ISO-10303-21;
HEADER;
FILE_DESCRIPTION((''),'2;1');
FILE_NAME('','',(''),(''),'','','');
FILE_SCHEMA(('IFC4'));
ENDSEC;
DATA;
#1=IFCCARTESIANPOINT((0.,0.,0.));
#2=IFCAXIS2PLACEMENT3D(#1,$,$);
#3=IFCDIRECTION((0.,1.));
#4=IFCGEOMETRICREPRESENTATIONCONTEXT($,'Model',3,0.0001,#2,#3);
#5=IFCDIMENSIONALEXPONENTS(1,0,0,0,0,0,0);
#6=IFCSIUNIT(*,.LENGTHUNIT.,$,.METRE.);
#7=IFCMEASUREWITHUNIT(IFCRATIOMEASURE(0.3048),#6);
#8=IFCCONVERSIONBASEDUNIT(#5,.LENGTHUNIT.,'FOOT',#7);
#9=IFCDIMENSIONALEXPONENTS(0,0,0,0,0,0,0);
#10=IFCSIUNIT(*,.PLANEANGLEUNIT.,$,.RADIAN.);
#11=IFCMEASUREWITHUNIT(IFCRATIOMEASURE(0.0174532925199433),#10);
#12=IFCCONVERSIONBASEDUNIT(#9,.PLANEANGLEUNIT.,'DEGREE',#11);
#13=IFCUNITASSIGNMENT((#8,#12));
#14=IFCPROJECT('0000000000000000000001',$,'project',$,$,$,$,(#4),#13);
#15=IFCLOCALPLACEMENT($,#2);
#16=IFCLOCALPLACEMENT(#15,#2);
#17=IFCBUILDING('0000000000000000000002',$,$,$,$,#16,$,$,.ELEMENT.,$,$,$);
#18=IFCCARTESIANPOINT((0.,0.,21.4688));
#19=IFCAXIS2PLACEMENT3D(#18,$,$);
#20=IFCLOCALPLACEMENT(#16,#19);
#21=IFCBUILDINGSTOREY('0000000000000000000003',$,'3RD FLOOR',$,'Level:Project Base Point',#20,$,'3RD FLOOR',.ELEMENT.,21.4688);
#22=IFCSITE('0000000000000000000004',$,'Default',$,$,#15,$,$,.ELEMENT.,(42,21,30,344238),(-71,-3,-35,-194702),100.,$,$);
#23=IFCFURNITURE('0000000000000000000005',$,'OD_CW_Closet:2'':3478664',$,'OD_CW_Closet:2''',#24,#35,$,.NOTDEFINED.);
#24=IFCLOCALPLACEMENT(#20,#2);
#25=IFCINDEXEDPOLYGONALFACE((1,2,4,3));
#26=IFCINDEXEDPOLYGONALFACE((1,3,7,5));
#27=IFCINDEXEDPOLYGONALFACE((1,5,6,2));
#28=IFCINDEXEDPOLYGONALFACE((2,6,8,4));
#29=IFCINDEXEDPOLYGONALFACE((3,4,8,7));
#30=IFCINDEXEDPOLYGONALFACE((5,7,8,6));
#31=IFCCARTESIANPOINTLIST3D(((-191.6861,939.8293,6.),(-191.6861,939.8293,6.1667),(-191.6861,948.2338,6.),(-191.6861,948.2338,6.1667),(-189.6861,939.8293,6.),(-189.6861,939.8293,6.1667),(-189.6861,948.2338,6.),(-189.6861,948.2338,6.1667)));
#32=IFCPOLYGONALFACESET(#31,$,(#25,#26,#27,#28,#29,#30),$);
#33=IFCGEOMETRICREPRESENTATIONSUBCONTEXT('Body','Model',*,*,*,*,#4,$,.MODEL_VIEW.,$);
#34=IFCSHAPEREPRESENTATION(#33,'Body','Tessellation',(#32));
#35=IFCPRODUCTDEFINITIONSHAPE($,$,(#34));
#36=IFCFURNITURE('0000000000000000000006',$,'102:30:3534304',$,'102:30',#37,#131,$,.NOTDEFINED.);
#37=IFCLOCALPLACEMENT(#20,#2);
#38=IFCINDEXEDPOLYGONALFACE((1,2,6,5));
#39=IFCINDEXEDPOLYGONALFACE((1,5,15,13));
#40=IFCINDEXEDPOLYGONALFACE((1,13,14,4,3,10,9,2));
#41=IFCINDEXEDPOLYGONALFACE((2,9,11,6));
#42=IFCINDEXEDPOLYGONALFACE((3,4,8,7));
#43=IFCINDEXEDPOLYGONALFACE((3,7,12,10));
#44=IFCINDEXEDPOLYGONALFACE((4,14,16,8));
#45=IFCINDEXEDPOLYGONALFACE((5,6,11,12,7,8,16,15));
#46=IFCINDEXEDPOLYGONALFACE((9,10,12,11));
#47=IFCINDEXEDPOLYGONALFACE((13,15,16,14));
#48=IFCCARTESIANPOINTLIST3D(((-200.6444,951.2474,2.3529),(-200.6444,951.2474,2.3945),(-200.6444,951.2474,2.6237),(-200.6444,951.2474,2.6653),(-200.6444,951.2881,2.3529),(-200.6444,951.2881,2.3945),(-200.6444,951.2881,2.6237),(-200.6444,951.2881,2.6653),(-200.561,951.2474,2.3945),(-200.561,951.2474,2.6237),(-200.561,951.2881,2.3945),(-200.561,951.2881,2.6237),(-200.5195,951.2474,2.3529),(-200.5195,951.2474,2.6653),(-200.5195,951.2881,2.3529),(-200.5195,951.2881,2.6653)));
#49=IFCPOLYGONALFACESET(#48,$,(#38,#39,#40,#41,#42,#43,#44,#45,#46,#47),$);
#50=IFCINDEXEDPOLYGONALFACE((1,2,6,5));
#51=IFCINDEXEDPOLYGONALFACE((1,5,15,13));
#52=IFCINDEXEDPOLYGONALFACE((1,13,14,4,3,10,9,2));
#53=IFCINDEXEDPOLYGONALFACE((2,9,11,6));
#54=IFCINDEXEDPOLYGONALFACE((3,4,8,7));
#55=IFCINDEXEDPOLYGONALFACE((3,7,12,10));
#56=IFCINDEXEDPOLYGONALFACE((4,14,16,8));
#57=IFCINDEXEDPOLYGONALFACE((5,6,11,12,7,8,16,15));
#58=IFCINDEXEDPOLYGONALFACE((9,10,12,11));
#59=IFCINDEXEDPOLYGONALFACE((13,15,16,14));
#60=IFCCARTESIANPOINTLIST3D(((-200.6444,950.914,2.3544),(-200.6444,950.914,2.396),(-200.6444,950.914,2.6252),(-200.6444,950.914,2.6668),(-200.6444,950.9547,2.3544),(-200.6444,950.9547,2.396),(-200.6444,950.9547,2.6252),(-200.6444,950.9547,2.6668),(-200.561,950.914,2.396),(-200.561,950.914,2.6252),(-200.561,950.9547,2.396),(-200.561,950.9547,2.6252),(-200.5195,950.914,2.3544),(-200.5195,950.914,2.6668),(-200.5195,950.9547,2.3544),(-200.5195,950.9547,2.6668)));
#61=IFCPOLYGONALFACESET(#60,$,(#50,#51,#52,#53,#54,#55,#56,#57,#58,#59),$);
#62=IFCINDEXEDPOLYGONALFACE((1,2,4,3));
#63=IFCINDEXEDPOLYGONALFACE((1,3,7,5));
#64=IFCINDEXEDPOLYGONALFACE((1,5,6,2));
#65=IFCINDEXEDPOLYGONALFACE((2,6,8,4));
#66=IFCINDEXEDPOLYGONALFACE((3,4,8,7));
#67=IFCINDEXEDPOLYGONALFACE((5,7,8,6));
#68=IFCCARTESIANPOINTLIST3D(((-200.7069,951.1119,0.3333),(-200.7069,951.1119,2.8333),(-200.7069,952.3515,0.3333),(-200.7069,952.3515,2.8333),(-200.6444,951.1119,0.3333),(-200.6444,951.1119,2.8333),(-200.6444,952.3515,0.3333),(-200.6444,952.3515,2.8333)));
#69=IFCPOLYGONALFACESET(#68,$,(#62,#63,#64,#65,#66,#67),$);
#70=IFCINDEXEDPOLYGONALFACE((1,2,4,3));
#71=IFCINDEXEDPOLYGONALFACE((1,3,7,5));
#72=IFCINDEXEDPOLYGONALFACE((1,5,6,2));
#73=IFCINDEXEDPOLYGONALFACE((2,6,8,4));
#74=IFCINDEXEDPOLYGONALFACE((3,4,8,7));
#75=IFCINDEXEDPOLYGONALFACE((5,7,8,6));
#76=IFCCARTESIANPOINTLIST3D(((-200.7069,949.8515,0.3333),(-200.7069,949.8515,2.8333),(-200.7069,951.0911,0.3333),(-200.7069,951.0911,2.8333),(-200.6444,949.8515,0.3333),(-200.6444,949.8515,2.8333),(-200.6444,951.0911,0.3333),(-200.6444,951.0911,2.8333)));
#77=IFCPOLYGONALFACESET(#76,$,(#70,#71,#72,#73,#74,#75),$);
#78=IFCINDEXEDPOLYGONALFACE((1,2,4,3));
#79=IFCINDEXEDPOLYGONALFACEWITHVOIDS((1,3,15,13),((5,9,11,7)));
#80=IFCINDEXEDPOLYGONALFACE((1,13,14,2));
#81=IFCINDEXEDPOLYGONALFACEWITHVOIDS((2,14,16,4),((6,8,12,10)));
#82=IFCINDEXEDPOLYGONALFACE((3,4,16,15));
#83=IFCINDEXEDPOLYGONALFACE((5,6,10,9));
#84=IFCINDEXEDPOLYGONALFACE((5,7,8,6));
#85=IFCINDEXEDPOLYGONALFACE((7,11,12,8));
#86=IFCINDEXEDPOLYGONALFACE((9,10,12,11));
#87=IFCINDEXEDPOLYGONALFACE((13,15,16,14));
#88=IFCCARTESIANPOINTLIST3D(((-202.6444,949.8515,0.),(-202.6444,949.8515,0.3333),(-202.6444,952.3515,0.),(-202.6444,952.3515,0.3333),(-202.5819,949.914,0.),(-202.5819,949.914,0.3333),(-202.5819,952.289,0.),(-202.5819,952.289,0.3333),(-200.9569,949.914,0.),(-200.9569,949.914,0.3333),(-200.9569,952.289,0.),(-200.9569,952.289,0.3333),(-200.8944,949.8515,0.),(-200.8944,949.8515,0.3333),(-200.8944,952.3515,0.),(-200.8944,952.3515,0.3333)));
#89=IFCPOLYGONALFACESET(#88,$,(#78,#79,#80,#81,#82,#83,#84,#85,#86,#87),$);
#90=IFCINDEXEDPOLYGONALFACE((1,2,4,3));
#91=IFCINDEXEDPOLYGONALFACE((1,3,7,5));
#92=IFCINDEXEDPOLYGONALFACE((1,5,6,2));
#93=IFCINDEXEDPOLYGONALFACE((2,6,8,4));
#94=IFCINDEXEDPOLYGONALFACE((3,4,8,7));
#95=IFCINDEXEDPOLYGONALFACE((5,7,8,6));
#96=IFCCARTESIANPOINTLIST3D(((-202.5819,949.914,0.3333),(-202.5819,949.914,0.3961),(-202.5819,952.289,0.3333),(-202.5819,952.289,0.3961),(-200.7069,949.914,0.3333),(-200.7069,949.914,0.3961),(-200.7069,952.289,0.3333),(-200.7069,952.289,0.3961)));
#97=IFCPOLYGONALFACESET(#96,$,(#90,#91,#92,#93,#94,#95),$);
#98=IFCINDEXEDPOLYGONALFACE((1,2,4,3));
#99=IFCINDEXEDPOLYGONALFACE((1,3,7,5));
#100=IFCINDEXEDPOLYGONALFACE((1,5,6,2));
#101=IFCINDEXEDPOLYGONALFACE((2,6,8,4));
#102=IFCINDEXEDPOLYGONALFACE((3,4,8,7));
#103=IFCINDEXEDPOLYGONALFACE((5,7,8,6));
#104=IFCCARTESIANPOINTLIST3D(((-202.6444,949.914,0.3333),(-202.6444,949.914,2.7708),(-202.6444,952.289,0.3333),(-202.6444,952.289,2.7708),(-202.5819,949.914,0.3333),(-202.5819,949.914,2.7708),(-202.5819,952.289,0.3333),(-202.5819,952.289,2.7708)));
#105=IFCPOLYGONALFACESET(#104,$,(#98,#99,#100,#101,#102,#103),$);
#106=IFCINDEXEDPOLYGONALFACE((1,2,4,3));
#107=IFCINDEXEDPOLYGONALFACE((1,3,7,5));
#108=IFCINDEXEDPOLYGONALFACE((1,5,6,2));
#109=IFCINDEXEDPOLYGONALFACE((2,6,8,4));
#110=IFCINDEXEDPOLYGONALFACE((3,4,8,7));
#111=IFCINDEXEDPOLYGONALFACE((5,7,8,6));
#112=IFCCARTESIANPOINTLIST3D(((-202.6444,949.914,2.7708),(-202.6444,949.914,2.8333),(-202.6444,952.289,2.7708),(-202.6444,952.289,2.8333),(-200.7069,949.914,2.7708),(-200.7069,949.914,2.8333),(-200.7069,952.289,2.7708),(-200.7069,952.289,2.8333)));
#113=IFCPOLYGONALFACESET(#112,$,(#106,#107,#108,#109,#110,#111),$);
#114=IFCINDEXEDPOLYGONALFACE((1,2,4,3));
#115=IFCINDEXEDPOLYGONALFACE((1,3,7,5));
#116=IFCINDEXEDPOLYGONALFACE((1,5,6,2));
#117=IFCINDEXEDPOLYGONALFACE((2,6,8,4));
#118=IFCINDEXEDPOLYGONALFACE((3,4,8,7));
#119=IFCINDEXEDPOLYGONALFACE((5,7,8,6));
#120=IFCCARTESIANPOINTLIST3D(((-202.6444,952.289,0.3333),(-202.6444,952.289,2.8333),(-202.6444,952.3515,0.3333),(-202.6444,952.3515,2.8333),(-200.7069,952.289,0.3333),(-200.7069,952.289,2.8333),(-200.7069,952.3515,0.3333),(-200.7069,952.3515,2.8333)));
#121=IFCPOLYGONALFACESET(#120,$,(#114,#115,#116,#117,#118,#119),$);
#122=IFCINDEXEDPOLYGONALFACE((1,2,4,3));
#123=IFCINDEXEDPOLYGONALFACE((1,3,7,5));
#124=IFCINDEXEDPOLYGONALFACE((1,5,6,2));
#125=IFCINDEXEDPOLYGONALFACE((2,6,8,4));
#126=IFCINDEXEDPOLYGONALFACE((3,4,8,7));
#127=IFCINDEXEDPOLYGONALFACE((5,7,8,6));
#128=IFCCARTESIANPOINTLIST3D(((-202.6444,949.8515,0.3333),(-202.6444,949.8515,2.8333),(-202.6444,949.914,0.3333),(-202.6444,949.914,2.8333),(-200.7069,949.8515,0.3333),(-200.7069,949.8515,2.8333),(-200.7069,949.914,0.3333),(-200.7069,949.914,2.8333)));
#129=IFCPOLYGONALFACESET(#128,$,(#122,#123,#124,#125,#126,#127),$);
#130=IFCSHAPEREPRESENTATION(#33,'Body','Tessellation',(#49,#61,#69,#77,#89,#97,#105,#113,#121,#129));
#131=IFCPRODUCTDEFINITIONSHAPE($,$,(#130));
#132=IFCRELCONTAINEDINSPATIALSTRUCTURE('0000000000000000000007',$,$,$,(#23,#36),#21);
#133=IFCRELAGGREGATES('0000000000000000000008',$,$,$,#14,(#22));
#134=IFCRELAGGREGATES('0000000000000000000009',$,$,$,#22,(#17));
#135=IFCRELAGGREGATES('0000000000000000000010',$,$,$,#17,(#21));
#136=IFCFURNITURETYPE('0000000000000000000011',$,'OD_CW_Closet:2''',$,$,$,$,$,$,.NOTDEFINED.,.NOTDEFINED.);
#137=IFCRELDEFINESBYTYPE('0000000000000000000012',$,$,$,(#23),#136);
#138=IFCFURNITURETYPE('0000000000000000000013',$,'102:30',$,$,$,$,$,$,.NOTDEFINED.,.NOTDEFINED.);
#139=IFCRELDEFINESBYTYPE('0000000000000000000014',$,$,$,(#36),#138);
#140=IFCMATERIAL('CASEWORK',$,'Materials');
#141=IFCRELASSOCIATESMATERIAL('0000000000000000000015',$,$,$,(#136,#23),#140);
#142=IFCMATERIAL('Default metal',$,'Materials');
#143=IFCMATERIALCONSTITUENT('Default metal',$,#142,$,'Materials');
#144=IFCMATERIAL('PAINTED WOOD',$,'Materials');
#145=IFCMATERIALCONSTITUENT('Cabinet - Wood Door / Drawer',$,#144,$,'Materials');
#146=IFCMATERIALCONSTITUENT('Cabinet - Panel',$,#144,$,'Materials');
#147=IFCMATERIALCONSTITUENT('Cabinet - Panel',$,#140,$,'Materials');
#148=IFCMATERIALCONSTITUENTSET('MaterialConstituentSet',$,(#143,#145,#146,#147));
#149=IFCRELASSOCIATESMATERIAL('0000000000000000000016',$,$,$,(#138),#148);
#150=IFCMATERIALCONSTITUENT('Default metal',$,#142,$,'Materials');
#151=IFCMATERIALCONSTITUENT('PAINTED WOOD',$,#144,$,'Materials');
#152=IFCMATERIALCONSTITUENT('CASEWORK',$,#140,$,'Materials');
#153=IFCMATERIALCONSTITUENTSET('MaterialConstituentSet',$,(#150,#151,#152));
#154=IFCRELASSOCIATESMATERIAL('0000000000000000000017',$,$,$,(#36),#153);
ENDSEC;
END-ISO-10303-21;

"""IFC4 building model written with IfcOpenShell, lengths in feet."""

from ifc_helpers import new_model, entity, si_unit, converted_unit, direction, frame, frame_2d, origin, origin_2d_with_axis, place, context, subcontext, project, spatial, polyline, rectangle, outline, extrude, source, transform, mapped, material, constituent, constituent_set, type_object, type_shapes, element, save


model = new_model("IFC4")

# Units and contexts
model_context = context("Model", 3, precision=0.0001, world=origin(), true_north=direction((0.0, 1.0)))
body_context = subcontext(model_context, "Body", "Model", "MODEL_VIEW")
ifc_project = project(units=[converted_unit("LENGTHUNIT", "FOOT", entity("IfcRatioMeasure", 0.3048), si_unit("LENGTHUNIT", "METRE"), dimensions=[1, 0, 0, 0, 0, 0, 0]), converted_unit("PLANEANGLEUNIT", "DEGREE", entity("IfcRatioMeasure", 0.0174532925199433), si_unit("PLANEANGLEUNIT", "RADIAN"), dimensions=[0, 0, 0, 0, 0, 0, 0])], contexts=[model_context])

# Site, building, storey
site_placement = place(None, origin())
site = spatial("IfcSite", under=ifc_project, at=site_placement, Name="Default", CompositionType="ELEMENT", RefLatitude=(42, 21, 30, 344238), RefLongitude=(-71, -3, -35, -194702), RefElevation=100.0)
building_placement = place(site_placement, origin())
building = spatial("IfcBuilding", under=site, at=building_placement, CompositionType="ELEMENT")
storey_placement = place(building_placement, frame((0.0, 0.0, 21.4688)))
storey = spatial("IfcBuildingStorey", under=building, at=storey_placement, Name="3RD FLOOR", ObjectType="Level:Project Base Point", LongName="3RD FLOOR", CompositionType="ELEMENT", Elevation=21.4688)

# Furniture
ifc_material_1 = material(Name="Default metal", Category="Materials")
ifc_material_2 = material(Name="PAINTED WOOD", Category="Materials")
ifc_material_3 = material(Name="CASEWORK", Category="Materials")
furniture_type_1 = type_object("IfcFurnitureType", Name="OD_CW_Closet:2'", AssemblyPlace="NOTDEFINED", PredefinedType="NOTDEFINED", material=ifc_material_3)
shared_shape_1 = source(origin(), body_context, "Body", "SweptSolid", [
    extrude(rectangle(XDim=8.4045, YDim=2.0, at=frame_2d((0.0, 0.0), x_axis=(1.0, 0.0))), frame((4.2022, 1.0, 0.0)), (0.0, 0.0, 1.0), 0.1667),
])
type_shapes(furniture_type_1, [shared_shape_1])
furniture_1_placement = place(storey_placement, frame((-191.6861, 948.2338, 6.0), z_axis=(0.0, 0.0, 1.0), x_axis=(0.0, -1.0, 0.0)))
element("IfcFurniture", 1, at=furniture_1_placement, inside=storey, type_object=furniture_type_1, material=ifc_material_3, Name="OD_CW_Closet:2':3478664", ObjectType="OD_CW_Closet:2'", PredefinedType="NOTDEFINED", context=body_context, shape_type="MappedRepresentation", body=[
    mapped(shared_shape_1, transform((0.0, 0.0, 0.0), scale=1.0)),
])
ifc_constituent_1 = constituent(ifc_material_1, Name="Default metal", Category="Materials")
ifc_constituent_2 = constituent(ifc_material_2, Name="PAINTED WOOD", Category="Materials")
ifc_constituent_3 = constituent(ifc_material_3, Name="CASEWORK", Category="Materials")
ifc_constituent_set_1 = constituent_set(constituents=[ifc_constituent_1, ifc_constituent_2, ifc_constituent_3], Name="MaterialConstituentSet")
ifc_constituent_4 = constituent(ifc_material_1, Name="Default metal", Category="Materials")
ifc_constituent_5 = constituent(ifc_material_2, Name="Cabinet - Wood Door / Drawer", Category="Materials")
ifc_constituent_6 = constituent(ifc_material_2, Name="Cabinet - Panel", Category="Materials")
ifc_constituent_7 = constituent(ifc_material_3, Name="Cabinet - Panel", Category="Materials")
ifc_constituent_set_2 = constituent_set(constituents=[ifc_constituent_4, ifc_constituent_5, ifc_constituent_6, ifc_constituent_7], Name="MaterialConstituentSet")
furniture_type_2 = type_object("IfcFurnitureType", Name="102:30", AssemblyPlace="NOTDEFINED", PredefinedType="NOTDEFINED", material=ifc_constituent_set_2)
shared_shape_2 = source(origin(), body_context, "Body", "SweptSolid", [
    extrude(outline(polyline([(0.1146, -0.0521), (0.1562, -0.0521), (0.1562, 0.0729), (-0.1562, 0.0729), (-0.1562, -0.0521), (-0.1146, -0.0521), (-0.1146, 0.0313), (0.1146, 0.0313), (0.1146, -0.0521)])), frame((0.2073, -2.0521, 2.5091), z_axis=(1.0, 0.0, 0.0), x_axis=(0.0, 0.0, 1.0)), (0.0, 0.0, 1.0), 0.0407),
    extrude(outline(polyline([(0.1146, -0.0521), (0.1562, -0.0521), (0.1562, 0.0729), (-0.1562, 0.0729), (-0.1562, -0.0521), (-0.1146, -0.0521), (-0.1146, 0.0313), (0.1146, 0.0313), (0.1146, -0.0521)])), frame((-0.126, -2.0521, 2.5106), z_axis=(1.0, 0.0, 0.0), x_axis=(0.0, 0.0, 1.0)), (0.0, 0.0, 1.0), 0.0407),
    extrude(rectangle(XDim=0.0625, YDim=1.2396, at=frame_2d((0.0, 0.0), x_axis=(1.0, 0.0))), frame((0.6917, -1.9688, 0.3333), z_axis=(0.0, 0.0, 1.0), x_axis=(0.0, 1.0, 0.0)), (0.0, 0.0, 1.0), 2.5),
    extrude(rectangle(XDim=0.0625, YDim=1.2396, at=origin_2d_with_axis()), frame((-0.5687, -1.9688, 0.3333), z_axis=(0.0, 0.0, 1.0), x_axis=(0.0, 1.0, 0.0)), (0.0, 0.0, 1.0), 2.5),
    extrude(outline(polyline([(-1.25, -0.875), (1.25, -0.875), (1.25, 0.875), (-1.25, 0.875), (-1.25, -0.875)]), holes=[polyline([(-1.1875, -0.8125), (-1.1875, 0.8125), (1.1875, 0.8125), (1.1875, -0.8125), (-1.1875, -0.8125)])]), frame((0.0615, -0.875, 0.0)), (0.0, 0.0, 1.0), 0.3333),
    extrude(rectangle(XDim=2.375, YDim=1.875, at=frame_2d((0.0, 0.0), x_axis=(1.0, 0.0))), frame((0.0615, -1.0, 0.3333), z_axis=(0.0, 0.0, 1.0), x_axis=(-1.0, 0.0, 0.0)), (0.0, 0.0, 1.0), 0.0627),
    extrude(rectangle(XDim=0.0625, YDim=2.375, at=origin_2d_with_axis()), frame((0.0615, -0.0312, 0.3333), z_axis=(0.0, 0.0, 1.0), x_axis=(0.0, 1.0, 0.0)), (0.0, 0.0, 1.0), 2.4375),
    extrude(rectangle(XDim=2.375, YDim=1.9375, at=origin_2d_with_axis()), frame((0.0615, -0.9688, 2.7708), z_axis=(0.0, 0.0, 1.0), x_axis=(-1.0, 0.0, 0.0)), (0.0, 0.0, 1.0), 0.0625),
    extrude(rectangle(XDim=0.0625, YDim=1.9375, at=frame_2d((0.0, 0.0), x_axis=(1.0, 0.0))), frame((1.2802, -0.9687, 0.3333)), (0.0, 0.0, 1.0), 2.5),
    extrude(rectangle(XDim=0.0625, YDim=1.9375, at=frame_2d((0.0, 0.0), x_axis=(1.0, 0.0))), frame((-1.1573, -0.9687, 0.3333)), (0.0, 0.0, 1.0), 2.5),
])
type_shapes(furniture_type_2, [shared_shape_2])
furniture_2_placement = place(storey_placement, frame((-202.6444, 951.04, 0.0), z_axis=(0.0, 0.0, 1.0), x_axis=(0.0, 1.0, 0.0)))
element("IfcFurniture", 2, at=furniture_2_placement, inside=storey, type_object=furniture_type_2, material=ifc_constituent_set_1, Name="102:30:3534304", ObjectType="102:30", PredefinedType="NOTDEFINED", context=body_context, shape_type="MappedRepresentation", body=[
    mapped(shared_shape_2, transform((0.0, 0.0, 0.0), scale=1.0)),
])

save(model, "model.ifc")
